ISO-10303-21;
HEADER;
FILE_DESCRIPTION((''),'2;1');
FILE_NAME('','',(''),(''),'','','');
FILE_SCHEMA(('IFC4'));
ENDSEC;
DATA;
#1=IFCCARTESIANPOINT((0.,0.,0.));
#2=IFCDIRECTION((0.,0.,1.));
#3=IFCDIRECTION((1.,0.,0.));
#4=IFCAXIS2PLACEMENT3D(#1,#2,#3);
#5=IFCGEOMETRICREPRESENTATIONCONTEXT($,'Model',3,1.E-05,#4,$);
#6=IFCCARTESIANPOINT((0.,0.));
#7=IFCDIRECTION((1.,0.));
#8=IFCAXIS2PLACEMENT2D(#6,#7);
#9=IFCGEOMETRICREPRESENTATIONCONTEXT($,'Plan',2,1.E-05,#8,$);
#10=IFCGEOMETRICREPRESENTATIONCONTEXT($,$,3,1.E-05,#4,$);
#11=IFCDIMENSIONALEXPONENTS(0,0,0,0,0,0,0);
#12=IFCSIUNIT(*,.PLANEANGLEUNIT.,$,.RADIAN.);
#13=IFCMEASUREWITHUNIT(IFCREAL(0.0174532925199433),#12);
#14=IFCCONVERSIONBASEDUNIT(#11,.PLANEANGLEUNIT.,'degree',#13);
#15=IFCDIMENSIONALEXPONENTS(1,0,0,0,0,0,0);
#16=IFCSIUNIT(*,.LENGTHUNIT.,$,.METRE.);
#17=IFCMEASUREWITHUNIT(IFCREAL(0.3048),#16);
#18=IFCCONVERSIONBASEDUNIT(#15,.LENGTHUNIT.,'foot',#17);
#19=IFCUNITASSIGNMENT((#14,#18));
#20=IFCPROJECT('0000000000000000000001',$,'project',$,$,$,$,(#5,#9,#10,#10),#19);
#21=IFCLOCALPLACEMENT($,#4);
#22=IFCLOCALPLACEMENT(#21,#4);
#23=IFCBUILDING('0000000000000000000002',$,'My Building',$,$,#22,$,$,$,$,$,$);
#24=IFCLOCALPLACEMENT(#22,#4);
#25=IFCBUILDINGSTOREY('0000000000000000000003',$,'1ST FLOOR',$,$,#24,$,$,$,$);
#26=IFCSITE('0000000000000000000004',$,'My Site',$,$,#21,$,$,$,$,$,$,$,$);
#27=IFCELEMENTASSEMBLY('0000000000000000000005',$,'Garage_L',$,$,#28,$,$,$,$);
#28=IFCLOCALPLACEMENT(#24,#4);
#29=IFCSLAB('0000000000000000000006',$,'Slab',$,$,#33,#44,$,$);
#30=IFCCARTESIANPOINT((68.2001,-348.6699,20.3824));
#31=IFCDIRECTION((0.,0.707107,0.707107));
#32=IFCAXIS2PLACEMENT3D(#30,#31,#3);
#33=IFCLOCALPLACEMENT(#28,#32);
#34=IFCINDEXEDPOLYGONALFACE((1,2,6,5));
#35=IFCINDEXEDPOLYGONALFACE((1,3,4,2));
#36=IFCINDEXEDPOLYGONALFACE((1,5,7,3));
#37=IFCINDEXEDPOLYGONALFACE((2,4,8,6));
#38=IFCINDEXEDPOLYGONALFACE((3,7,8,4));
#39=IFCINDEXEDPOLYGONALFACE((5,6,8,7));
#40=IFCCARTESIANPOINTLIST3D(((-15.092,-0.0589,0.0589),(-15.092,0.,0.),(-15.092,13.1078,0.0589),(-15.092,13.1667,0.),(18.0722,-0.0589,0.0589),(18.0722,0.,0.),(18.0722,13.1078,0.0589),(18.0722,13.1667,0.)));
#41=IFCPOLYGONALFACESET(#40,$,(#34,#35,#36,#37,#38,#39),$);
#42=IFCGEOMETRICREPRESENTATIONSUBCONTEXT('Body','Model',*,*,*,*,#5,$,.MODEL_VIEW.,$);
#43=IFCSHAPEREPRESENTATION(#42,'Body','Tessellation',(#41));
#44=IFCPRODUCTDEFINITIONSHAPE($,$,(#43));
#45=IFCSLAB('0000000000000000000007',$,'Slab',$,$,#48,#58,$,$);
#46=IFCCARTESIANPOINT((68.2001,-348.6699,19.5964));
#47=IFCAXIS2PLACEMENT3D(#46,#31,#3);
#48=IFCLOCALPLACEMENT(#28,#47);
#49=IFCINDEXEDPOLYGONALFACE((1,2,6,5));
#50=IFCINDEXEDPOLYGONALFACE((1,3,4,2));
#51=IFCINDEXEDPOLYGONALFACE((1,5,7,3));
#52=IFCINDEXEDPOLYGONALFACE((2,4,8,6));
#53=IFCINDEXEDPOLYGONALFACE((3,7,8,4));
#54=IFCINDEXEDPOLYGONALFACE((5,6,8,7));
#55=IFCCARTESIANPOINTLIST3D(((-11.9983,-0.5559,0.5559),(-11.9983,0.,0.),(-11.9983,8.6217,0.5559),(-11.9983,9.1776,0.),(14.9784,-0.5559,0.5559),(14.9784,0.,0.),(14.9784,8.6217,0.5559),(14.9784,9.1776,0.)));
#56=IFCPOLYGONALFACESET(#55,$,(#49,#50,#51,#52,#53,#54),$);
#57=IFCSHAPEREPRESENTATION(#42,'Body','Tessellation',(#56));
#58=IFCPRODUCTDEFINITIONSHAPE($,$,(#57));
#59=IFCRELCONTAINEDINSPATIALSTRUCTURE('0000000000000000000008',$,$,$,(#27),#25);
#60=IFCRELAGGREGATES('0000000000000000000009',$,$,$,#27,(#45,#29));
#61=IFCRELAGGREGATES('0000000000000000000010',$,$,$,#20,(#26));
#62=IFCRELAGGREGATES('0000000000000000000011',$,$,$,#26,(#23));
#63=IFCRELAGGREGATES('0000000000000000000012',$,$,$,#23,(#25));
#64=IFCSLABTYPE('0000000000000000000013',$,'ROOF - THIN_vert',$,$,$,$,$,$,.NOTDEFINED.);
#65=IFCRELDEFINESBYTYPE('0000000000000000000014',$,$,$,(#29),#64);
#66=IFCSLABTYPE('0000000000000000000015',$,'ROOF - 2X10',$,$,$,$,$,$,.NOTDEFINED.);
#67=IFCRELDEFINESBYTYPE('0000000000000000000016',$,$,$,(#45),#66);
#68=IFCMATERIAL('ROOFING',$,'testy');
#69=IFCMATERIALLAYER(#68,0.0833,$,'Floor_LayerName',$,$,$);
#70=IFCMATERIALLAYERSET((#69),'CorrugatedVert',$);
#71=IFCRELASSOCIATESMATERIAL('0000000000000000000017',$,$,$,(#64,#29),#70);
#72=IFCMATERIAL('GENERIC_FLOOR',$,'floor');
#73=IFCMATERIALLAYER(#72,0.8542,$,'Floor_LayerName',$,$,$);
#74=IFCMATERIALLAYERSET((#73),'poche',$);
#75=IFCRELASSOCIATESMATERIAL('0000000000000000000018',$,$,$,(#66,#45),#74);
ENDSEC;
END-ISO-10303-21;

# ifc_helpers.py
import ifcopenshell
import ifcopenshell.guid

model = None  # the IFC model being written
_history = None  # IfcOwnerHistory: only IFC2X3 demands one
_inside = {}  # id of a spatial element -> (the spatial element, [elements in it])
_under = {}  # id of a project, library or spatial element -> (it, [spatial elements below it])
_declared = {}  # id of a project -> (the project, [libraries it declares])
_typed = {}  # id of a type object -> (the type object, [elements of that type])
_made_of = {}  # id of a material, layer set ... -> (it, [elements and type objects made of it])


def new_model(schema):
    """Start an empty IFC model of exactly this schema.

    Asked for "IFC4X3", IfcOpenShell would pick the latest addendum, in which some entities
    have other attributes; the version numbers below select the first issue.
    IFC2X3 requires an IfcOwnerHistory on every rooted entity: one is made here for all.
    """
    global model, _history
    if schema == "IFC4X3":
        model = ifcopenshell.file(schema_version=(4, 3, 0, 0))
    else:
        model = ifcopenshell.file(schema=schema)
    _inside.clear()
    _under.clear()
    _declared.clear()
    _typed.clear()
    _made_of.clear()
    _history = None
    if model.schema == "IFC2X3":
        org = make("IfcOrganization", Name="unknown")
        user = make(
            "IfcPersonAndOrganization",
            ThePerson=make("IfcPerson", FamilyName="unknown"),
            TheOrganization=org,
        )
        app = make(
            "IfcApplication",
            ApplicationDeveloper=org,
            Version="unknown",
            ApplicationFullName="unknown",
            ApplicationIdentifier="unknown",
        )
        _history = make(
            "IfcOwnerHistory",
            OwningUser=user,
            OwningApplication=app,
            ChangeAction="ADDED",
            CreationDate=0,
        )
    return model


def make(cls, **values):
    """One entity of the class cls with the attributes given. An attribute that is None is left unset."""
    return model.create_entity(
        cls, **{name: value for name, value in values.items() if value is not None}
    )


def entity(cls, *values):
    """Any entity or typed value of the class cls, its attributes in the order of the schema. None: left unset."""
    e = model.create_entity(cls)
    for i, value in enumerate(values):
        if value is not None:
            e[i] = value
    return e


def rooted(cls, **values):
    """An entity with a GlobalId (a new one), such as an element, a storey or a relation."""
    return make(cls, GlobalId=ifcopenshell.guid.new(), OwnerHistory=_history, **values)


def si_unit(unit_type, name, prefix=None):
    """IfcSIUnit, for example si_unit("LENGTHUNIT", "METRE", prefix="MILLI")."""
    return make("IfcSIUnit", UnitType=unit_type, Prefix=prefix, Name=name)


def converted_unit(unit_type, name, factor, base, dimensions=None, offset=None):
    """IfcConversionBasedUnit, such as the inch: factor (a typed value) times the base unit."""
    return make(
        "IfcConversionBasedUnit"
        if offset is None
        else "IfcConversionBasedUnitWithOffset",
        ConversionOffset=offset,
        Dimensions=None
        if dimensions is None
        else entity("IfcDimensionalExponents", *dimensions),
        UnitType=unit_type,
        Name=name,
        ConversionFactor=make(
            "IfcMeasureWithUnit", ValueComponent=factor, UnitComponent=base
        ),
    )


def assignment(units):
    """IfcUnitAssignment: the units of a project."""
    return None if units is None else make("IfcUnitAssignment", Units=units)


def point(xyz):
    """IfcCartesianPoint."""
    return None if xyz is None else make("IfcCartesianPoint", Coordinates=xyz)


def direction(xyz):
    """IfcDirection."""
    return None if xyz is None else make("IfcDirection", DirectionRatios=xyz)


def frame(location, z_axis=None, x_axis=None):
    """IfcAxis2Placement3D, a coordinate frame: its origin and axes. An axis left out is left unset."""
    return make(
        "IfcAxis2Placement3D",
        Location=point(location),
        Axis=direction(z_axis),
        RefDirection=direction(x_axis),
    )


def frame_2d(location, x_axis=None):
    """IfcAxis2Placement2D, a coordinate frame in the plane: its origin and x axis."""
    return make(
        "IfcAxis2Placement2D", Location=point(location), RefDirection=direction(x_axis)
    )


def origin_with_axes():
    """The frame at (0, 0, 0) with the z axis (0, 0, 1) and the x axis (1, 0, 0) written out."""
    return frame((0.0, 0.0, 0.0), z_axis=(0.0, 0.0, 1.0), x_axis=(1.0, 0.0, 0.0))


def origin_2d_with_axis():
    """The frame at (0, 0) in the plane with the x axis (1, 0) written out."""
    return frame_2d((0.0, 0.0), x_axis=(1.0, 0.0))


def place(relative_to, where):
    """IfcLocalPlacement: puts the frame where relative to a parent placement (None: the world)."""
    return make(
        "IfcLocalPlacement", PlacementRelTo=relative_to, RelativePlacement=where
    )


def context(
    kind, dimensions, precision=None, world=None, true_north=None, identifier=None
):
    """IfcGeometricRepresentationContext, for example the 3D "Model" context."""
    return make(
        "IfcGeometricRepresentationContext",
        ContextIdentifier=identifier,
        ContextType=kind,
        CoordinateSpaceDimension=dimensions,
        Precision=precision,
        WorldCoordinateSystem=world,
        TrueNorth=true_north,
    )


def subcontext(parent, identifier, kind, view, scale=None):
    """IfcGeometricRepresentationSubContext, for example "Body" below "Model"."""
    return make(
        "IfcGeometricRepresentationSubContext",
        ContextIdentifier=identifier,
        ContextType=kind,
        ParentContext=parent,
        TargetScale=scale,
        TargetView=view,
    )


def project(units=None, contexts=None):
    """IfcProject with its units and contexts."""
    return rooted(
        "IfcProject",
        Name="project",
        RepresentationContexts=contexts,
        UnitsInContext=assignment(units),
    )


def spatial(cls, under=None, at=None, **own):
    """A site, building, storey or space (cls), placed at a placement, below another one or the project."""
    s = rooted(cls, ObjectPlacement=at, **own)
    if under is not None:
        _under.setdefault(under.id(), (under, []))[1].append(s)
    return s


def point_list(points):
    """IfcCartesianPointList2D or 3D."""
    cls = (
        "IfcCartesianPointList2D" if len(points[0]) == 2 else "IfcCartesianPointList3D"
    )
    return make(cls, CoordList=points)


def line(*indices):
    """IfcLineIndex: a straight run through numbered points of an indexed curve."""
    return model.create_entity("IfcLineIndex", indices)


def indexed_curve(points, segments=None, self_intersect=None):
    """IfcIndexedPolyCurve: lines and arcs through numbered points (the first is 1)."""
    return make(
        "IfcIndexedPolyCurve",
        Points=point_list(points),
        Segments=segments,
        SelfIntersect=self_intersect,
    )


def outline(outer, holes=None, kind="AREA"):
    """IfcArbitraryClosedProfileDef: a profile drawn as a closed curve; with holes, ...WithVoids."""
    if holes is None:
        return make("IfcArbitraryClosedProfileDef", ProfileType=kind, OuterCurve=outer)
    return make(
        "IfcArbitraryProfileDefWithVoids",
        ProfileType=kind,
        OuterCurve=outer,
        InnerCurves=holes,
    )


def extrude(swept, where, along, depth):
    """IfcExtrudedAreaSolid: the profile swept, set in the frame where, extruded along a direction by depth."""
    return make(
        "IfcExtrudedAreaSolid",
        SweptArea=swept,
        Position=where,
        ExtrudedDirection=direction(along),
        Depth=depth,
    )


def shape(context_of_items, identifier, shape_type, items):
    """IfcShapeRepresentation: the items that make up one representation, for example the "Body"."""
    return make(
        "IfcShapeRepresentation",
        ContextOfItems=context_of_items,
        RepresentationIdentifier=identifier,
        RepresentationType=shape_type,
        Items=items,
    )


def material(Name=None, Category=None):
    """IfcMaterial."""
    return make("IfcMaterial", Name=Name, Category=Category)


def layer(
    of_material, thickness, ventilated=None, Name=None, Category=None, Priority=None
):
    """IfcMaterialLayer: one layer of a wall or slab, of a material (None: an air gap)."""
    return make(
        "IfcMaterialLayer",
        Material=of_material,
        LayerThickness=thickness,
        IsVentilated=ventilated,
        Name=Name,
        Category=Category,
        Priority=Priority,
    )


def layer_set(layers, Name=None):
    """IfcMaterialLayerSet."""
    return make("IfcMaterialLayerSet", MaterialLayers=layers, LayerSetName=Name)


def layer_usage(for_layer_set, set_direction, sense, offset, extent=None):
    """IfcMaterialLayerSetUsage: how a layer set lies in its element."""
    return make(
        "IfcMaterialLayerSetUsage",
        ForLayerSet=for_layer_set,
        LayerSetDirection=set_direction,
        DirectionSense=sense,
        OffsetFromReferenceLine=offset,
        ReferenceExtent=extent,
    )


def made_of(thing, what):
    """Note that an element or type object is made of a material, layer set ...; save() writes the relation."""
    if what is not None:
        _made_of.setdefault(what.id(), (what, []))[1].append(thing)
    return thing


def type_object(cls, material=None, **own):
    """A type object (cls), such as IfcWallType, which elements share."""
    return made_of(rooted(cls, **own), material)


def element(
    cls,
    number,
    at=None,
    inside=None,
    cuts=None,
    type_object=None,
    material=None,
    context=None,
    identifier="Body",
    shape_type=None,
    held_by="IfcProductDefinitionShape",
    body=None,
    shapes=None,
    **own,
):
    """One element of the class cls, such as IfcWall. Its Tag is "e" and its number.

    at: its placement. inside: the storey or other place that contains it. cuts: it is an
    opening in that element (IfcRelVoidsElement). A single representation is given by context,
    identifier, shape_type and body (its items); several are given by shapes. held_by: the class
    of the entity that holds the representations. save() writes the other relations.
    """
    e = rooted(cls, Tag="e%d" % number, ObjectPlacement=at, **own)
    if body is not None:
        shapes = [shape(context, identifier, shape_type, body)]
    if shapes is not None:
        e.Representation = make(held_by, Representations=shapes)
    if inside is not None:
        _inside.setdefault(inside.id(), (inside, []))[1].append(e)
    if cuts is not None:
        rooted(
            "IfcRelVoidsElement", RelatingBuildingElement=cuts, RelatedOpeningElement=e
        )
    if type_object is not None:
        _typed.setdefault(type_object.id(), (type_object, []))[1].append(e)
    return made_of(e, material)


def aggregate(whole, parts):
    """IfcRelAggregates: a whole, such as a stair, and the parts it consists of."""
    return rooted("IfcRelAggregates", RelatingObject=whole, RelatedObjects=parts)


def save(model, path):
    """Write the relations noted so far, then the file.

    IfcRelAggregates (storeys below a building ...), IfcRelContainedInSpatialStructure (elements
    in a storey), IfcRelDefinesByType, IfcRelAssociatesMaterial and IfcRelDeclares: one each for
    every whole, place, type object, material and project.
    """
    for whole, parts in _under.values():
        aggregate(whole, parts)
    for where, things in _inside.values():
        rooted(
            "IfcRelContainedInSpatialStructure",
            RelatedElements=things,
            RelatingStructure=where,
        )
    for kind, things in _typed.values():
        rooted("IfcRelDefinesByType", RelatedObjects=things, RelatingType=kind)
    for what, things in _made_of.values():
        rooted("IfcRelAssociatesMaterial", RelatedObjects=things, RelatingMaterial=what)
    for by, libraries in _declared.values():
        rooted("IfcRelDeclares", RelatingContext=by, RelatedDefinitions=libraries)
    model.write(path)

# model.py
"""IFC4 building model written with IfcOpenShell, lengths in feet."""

from ifc_helpers import new_model, entity, si_unit, converted_unit, frame, origin_with_axes, origin_2d_with_axis, place, context, subcontext, project, spatial, line, indexed_curve, outline, extrude, material, layer, layer_set, layer_usage, type_object, element, aggregate, save


model = new_model("IFC4")

# Units and contexts
model_context = context("Model", 3, precision=1e-05, world=origin_with_axes())
plan_context = context("Plan", 2, precision=1e-05, world=origin_2d_with_axis())
context_of_model = context(None, 3, precision=1e-05, world=origin_with_axes())
body_context = subcontext(model_context, "Body", "Model", "MODEL_VIEW")
ifc_project = project(units=[converted_unit("PLANEANGLEUNIT", "degree", entity("IfcReal", 0.0174532925199433), si_unit("PLANEANGLEUNIT", "RADIAN"), dimensions=[0, 0, 0, 0, 0, 0, 0]), converted_unit("LENGTHUNIT", "foot", entity("IfcReal", 0.3048), si_unit("LENGTHUNIT", "METRE"), dimensions=[1, 0, 0, 0, 0, 0, 0])], contexts=[model_context, plan_context, context_of_model, context_of_model])

# Site, building, storey
site_placement = place(None, origin_with_axes())
site = spatial("IfcSite", under=ifc_project, at=site_placement, Name="My Site")
building_placement = place(site_placement, origin_with_axes())
building = spatial("IfcBuilding", under=site, at=building_placement, Name="My Building")
storey_placement = place(building_placement, origin_with_axes())
storey = spatial("IfcBuildingStorey", under=building, at=storey_placement, Name="1ST FLOOR")

# Element assembly
assembly_1_placement = place(storey_placement, origin_with_axes())
assembly_1 = element("IfcElementAssembly", 1, at=assembly_1_placement, inside=storey, Name="Garage_L")

# Slabs
ifc_material_1 = material(Name="ROOFING", Category="testy")
ifc_layer_1 = layer(ifc_material_1, 0.0833, Name="Floor_LayerName")
ifc_layer_set_1 = layer_set([ifc_layer_1], Name="CorrugatedVert")
ifc_layer_usage_1 = layer_usage(ifc_layer_set_1, "AXIS3", "POSITIVE", 0.0)
slab_type_1 = type_object("IfcSlabType", Name="ROOF - THIN_vert", PredefinedType="NOTDEFINED", material=ifc_layer_set_1)
slab_1_placement = place(assembly_1_placement, frame((68.2001, -348.6699, 20.3824), z_axis=(0.0, 0.707107, 0.707107), x_axis=(1.0, 0.0, 0.0)))
slab_1 = element("IfcSlab", 2, at=slab_1_placement, type_object=slab_type_1, material=ifc_layer_usage_1, Name="Slab", context=body_context, shape_type="SweptSolid", body=[
    extrude(outline(indexed_curve([(-15.092, 0.0), (18.0722, 0.0), (18.0722, 13.1667), (-15.092, 13.1667)], segments=[line(3, 2), line(2, 1), line(1, 4), line(4, 3)], self_intersect=False)), None, (0.0, -0.707107, 0.707107), 0.0833),
])
ifc_material_2 = material(Name="GENERIC_FLOOR", Category="floor")
ifc_layer_2 = layer(ifc_material_2, 0.8542, Name="Floor_LayerName")
ifc_layer_set_2 = layer_set([ifc_layer_2], Name="poche")
ifc_layer_usage_2 = layer_usage(ifc_layer_set_2, "AXIS3", "POSITIVE", 0.0)
slab_type_2 = type_object("IfcSlabType", Name="ROOF - 2X10", PredefinedType="NOTDEFINED", material=ifc_layer_set_2)
slab_2_placement = place(assembly_1_placement, frame((68.2001, -348.6699, 19.5964), z_axis=(0.0, 0.707107, 0.707107), x_axis=(1.0, 0.0, 0.0)))
slab_2 = element("IfcSlab", 3, at=slab_2_placement, type_object=slab_type_2, material=ifc_layer_usage_2, Name="Slab", context=body_context, shape_type="SweptSolid", body=[
    extrude(outline(indexed_curve([(-11.9983, 0.0), (-11.9983, 9.1776), (14.9784, 9.1776), (14.9784, 0.0)], segments=[line(4, 1), line(1, 2), line(2, 3), line(3, 4)], self_intersect=False)), None, (0.0, -0.707107, 0.707107), 0.7861),
])
aggregate(assembly_1, [slab_2, slab_1])

save(model, "model.ifc")
